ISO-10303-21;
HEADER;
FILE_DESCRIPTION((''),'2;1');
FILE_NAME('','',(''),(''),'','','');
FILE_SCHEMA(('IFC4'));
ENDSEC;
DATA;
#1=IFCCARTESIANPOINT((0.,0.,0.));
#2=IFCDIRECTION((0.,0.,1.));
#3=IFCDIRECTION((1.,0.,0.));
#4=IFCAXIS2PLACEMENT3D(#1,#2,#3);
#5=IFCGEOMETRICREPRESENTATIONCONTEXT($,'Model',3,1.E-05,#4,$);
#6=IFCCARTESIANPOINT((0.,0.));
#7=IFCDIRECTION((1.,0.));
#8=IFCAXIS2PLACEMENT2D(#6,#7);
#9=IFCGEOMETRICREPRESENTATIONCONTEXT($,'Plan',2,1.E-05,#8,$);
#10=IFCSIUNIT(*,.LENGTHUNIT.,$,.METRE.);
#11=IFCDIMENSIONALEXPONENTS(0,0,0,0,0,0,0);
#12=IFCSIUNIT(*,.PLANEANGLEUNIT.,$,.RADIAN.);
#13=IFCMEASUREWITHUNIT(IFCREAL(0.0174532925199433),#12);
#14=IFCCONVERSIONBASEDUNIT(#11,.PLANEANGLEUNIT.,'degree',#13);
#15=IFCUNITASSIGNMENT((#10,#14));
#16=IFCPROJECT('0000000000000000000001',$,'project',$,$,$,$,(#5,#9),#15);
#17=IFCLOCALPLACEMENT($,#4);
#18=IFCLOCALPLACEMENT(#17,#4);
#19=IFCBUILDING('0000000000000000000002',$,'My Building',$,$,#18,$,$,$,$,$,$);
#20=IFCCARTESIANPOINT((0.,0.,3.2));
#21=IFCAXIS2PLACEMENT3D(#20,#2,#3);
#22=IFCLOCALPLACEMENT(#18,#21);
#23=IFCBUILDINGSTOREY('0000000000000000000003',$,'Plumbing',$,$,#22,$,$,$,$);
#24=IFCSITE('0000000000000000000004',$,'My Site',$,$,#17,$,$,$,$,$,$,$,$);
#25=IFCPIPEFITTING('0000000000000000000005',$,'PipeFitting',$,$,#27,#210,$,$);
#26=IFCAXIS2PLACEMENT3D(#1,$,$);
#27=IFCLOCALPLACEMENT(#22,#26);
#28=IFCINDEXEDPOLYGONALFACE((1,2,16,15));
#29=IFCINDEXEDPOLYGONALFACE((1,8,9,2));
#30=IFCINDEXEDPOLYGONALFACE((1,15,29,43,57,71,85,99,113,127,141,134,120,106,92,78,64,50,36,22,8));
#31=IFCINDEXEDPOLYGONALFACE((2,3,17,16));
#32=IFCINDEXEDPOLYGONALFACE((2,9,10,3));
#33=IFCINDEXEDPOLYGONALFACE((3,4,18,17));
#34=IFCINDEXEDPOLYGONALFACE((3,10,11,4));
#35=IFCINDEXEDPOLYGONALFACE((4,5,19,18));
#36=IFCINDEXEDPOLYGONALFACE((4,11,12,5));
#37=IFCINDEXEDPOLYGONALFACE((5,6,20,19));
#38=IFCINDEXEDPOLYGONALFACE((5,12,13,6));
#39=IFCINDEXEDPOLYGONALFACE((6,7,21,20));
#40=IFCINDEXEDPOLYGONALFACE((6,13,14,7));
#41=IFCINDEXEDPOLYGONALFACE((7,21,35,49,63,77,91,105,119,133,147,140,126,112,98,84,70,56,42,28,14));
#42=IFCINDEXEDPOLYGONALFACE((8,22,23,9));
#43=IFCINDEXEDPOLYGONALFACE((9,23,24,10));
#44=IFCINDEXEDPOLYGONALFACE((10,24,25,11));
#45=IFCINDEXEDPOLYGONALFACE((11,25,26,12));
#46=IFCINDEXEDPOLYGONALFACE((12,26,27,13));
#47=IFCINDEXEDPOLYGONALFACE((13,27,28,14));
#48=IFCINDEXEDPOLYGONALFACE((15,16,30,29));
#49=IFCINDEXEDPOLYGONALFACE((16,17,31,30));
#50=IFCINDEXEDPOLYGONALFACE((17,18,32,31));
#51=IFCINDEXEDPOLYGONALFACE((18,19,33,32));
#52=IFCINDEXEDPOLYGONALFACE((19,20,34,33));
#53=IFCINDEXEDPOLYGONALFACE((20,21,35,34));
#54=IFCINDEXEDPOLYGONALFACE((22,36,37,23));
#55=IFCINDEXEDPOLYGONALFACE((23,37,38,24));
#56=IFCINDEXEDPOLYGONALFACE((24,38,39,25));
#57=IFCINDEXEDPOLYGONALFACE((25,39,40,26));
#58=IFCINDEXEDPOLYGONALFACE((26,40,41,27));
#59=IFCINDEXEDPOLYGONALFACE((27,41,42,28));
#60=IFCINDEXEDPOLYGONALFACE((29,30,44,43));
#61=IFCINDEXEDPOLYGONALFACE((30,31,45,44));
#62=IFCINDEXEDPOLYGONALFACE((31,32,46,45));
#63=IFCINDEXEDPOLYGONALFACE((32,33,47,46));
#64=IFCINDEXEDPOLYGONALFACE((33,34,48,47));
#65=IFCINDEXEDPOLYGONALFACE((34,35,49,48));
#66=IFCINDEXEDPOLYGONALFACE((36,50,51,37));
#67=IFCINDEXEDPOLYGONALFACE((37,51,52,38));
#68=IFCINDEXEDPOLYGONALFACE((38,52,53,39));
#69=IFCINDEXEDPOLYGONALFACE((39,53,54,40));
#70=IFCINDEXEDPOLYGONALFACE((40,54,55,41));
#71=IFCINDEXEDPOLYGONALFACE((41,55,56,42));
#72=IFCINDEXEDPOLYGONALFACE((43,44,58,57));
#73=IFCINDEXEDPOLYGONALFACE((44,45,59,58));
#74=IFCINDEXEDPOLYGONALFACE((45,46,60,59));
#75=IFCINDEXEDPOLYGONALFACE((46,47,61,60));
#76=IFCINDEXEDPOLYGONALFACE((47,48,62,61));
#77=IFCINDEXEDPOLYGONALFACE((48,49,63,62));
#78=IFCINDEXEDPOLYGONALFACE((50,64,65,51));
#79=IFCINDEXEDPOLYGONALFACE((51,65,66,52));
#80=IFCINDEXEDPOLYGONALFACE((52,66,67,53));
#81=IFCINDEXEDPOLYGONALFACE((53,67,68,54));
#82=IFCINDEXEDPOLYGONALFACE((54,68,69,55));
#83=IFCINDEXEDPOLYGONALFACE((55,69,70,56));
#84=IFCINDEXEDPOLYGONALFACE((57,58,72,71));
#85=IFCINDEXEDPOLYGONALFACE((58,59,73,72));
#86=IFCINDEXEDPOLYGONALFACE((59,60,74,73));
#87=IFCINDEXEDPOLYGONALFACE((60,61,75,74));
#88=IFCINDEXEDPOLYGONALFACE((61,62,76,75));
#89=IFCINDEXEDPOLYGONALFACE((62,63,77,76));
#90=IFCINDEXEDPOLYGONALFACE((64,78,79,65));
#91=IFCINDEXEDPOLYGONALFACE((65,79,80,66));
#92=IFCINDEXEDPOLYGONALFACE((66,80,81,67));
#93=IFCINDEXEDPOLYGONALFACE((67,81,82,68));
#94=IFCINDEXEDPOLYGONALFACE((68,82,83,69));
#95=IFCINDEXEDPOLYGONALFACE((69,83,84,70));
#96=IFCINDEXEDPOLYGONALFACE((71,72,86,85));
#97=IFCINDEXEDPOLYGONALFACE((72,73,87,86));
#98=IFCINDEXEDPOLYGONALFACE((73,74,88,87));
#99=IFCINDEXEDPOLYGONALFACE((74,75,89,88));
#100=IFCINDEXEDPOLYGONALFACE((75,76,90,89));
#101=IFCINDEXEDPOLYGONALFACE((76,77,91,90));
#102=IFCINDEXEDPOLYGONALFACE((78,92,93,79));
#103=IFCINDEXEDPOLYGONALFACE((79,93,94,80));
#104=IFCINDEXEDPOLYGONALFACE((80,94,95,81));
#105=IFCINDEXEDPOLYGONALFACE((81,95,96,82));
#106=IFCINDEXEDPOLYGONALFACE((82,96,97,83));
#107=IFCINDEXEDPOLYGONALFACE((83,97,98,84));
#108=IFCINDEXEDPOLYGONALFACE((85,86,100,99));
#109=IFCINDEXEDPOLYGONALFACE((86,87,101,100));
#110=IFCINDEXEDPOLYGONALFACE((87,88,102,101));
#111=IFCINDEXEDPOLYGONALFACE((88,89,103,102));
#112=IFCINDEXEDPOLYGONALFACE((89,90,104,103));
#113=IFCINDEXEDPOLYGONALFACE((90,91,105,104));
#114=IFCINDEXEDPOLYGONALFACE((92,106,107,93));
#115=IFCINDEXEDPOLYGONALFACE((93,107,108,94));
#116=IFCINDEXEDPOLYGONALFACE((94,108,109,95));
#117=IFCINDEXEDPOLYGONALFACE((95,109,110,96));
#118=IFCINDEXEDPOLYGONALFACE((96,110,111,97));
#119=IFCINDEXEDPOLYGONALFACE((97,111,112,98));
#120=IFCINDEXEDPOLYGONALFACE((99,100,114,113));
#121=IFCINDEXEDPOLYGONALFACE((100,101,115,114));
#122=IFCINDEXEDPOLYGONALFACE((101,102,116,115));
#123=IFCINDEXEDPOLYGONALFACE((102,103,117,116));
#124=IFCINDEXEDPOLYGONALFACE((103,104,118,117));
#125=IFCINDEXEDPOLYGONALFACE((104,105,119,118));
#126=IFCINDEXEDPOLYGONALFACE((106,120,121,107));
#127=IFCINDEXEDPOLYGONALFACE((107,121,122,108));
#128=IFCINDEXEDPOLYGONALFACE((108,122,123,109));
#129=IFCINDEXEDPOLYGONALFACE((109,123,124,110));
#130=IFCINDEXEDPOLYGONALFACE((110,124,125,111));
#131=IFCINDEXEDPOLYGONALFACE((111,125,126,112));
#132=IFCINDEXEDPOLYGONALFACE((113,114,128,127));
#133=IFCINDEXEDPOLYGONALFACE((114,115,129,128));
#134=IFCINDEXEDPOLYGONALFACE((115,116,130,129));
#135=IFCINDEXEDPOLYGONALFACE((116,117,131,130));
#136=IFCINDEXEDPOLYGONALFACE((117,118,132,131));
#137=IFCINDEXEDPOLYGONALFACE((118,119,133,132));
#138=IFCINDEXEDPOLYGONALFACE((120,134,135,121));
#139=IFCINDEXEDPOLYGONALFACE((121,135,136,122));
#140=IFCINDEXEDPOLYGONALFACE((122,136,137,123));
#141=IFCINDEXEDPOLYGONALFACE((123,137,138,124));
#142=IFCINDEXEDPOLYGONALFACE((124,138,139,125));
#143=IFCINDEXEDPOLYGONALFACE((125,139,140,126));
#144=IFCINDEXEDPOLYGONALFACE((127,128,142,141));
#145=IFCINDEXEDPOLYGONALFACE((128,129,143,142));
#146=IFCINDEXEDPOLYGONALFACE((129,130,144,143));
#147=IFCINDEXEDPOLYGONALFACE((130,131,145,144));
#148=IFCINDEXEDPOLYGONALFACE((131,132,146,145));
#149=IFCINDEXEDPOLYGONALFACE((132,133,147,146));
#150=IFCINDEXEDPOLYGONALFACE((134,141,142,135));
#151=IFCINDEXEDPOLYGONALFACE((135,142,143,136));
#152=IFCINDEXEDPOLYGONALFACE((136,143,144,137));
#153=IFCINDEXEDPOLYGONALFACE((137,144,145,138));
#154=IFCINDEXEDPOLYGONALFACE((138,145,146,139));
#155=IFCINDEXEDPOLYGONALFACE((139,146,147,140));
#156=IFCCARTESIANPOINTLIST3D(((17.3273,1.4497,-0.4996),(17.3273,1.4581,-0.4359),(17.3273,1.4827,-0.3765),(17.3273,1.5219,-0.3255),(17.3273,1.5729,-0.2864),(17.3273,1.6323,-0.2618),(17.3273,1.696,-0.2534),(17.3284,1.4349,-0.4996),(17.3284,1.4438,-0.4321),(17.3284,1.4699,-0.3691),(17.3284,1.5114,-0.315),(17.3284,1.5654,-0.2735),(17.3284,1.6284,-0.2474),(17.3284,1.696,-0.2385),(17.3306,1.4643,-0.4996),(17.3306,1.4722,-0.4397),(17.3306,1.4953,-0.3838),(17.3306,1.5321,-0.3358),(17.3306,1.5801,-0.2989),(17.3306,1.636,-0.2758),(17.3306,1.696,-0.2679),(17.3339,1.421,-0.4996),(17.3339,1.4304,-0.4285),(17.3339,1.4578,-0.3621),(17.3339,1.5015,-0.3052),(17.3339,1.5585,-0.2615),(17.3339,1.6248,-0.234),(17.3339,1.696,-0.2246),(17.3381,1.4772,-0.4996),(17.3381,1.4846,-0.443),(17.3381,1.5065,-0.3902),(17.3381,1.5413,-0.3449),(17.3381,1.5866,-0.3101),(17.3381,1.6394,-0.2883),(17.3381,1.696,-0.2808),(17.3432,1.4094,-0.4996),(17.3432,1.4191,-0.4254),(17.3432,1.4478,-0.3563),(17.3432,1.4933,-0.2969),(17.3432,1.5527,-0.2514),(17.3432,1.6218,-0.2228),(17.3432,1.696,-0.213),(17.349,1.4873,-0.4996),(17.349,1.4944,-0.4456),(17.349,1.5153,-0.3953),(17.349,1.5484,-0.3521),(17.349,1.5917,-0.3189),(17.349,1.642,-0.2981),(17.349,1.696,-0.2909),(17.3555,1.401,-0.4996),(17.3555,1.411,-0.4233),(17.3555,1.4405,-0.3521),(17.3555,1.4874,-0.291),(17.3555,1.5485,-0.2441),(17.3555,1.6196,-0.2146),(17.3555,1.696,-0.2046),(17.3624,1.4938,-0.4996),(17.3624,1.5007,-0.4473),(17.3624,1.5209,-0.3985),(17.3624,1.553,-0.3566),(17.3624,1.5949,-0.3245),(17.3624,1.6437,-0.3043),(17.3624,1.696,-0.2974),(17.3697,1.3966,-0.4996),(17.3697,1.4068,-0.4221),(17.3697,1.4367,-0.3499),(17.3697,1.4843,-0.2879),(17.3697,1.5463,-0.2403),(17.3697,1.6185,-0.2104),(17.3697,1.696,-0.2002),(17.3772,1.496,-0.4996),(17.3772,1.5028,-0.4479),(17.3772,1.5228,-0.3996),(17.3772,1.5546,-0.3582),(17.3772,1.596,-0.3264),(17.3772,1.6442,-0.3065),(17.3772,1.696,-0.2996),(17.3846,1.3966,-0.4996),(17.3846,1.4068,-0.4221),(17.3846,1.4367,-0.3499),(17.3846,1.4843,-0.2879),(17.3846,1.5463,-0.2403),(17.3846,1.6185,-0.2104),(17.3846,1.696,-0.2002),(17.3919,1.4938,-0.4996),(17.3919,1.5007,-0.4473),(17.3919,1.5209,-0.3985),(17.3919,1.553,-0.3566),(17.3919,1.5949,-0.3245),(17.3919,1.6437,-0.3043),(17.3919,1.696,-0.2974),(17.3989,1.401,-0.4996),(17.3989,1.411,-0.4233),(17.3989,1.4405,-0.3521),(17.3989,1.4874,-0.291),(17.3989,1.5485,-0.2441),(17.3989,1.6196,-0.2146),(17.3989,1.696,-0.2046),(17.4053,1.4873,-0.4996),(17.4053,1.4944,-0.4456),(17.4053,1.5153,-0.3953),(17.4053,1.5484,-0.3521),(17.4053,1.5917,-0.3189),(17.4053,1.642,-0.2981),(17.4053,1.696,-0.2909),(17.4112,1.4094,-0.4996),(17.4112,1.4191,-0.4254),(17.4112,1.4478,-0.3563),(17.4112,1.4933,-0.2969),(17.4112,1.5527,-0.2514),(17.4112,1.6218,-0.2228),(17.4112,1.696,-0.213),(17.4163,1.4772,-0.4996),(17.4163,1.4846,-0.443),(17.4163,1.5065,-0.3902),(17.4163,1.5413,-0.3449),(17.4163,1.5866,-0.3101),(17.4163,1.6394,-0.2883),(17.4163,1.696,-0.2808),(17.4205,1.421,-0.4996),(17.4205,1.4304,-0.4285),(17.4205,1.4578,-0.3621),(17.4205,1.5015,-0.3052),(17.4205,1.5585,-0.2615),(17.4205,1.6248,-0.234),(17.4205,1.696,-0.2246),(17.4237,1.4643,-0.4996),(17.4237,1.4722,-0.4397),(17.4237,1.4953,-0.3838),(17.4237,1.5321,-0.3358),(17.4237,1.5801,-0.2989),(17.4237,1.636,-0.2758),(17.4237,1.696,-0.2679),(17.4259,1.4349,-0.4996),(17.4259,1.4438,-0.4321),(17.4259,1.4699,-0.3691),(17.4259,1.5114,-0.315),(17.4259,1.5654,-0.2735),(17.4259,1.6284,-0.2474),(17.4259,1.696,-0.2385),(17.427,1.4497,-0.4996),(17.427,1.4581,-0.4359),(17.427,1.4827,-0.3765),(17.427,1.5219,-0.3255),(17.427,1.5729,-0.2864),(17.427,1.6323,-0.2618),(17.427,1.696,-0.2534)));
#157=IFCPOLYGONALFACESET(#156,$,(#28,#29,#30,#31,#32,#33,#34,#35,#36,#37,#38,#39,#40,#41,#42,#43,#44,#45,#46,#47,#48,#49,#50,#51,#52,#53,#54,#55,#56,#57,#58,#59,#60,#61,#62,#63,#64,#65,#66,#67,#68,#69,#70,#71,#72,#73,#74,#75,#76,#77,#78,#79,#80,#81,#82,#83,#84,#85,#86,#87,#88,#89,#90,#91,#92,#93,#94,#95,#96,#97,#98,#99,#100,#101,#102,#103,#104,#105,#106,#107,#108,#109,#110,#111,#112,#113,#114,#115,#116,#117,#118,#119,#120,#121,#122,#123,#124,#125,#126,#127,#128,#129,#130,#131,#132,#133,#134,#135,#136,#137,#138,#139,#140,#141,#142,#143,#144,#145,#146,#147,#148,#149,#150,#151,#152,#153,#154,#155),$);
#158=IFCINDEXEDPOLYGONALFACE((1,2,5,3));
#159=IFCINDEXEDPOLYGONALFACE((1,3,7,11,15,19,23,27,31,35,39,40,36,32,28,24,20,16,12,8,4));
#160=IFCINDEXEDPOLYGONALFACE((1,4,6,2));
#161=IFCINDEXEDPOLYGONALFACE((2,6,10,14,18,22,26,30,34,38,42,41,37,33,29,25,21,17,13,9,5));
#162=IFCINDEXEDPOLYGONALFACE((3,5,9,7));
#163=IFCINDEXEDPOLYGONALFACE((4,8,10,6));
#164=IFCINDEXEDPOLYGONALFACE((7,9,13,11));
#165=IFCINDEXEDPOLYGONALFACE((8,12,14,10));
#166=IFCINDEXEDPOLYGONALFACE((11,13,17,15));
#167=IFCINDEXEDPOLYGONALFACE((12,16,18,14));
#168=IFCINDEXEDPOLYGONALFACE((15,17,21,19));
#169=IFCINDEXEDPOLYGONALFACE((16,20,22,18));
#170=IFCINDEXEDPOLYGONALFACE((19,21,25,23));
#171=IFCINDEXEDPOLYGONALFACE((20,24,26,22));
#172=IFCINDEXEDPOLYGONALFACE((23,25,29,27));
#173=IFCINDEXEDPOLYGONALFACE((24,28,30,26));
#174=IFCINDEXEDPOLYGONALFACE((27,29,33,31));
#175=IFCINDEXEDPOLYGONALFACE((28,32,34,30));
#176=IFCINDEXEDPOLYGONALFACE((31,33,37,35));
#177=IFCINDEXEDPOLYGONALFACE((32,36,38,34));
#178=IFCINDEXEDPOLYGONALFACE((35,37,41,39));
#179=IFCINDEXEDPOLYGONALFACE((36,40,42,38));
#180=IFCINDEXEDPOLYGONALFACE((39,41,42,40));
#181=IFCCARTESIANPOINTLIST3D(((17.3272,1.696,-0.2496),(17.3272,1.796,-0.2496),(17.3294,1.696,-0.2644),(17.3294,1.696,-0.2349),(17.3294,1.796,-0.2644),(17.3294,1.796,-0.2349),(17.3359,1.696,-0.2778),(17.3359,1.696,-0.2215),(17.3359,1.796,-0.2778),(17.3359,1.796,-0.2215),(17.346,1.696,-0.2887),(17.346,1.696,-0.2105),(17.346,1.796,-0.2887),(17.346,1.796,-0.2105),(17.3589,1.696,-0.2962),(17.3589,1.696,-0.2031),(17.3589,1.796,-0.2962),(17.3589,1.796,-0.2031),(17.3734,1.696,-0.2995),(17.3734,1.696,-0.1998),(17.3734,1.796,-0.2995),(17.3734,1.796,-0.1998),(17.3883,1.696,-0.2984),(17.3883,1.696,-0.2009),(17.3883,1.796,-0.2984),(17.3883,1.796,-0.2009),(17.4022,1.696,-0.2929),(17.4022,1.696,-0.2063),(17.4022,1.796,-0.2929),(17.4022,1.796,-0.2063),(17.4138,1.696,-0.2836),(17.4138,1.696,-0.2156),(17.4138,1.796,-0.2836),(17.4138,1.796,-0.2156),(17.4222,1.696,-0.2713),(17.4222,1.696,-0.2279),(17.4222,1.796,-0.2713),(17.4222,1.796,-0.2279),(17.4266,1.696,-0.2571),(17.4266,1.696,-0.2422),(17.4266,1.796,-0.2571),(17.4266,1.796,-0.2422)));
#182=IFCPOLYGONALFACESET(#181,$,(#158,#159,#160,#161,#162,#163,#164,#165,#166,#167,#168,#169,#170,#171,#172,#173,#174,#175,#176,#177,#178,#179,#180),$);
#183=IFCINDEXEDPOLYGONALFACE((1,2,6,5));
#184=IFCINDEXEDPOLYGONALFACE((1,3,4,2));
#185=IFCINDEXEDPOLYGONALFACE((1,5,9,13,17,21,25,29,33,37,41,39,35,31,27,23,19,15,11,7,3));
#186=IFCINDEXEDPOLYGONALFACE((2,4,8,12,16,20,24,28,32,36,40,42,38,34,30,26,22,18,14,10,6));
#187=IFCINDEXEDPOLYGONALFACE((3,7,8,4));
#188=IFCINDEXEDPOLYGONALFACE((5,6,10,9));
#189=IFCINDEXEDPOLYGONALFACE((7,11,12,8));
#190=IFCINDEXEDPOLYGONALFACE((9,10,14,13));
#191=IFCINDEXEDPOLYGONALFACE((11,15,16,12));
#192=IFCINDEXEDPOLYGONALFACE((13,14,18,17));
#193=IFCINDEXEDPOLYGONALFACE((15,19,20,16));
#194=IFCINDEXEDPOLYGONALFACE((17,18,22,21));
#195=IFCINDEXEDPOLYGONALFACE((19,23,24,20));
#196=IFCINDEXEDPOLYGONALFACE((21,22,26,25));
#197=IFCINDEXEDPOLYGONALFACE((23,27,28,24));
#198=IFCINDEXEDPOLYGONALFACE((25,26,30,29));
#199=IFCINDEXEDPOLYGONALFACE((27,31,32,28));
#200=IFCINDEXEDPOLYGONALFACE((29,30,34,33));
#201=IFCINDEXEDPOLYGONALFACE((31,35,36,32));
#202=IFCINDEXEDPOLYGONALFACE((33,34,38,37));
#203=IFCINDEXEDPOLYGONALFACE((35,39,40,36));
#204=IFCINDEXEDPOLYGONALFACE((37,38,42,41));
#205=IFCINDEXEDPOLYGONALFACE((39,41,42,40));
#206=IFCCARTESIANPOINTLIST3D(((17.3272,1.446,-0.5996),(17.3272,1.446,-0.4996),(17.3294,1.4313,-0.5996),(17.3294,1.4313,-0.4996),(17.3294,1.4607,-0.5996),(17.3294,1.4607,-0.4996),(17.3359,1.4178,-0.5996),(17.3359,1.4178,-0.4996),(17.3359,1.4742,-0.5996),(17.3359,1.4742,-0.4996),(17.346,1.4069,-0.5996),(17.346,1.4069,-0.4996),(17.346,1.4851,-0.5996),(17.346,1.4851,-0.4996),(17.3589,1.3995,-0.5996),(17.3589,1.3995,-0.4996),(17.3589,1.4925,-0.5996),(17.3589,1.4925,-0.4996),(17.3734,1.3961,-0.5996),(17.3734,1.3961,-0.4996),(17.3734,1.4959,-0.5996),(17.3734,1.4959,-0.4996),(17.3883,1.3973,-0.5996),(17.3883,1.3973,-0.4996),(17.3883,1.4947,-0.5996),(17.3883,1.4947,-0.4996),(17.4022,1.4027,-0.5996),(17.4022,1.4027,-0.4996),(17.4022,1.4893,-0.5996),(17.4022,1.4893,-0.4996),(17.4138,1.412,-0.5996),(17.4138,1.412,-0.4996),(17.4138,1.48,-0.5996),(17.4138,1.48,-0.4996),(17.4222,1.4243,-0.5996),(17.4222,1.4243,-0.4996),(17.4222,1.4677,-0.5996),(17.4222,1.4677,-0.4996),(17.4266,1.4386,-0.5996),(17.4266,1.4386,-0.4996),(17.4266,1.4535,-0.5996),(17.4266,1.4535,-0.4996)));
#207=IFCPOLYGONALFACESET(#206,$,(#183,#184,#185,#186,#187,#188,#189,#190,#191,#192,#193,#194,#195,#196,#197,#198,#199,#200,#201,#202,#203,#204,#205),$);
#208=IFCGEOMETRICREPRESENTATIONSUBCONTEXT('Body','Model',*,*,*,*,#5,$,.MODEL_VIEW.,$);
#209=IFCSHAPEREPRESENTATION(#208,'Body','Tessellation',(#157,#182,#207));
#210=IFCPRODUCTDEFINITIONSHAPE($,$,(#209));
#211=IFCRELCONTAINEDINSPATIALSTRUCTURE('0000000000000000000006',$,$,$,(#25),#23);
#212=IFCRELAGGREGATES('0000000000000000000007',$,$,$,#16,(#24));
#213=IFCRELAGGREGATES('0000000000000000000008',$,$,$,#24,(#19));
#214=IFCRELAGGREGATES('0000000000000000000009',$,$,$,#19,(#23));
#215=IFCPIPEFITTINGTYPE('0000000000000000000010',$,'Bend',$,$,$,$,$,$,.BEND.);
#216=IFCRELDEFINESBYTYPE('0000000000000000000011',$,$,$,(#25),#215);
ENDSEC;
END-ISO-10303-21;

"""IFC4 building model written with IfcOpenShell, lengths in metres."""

from ifc_helpers import new_model, entity, si_unit, converted_unit, frame, origin_with_axes, origin_2d_with_axis, place, context, subcontext, project, spatial, circle, extrude, source, transform, mapped, type_object, type_shapes, element, save


model = new_model("IFC4")

# Units and contexts
model_context = context("Model", 3, precision=1e-05, world=origin_with_axes())
plan_context = context("Plan", 2, precision=1e-05, world=origin_2d_with_axis())
body_context = subcontext(model_context, "Body", "Model", "MODEL_VIEW")
ifc_project = project(units=[si_unit("LENGTHUNIT", "METRE"), converted_unit("PLANEANGLEUNIT", "degree", entity("IfcReal", 0.0174532925199433), si_unit("PLANEANGLEUNIT", "RADIAN"), dimensions=[0, 0, 0, 0, 0, 0, 0])], contexts=[model_context, plan_context])

# Site, building, storey
site_placement = place(None, origin_with_axes())
site = spatial("IfcSite", under=ifc_project, at=site_placement, Name="My Site")
building_placement = place(site_placement, origin_with_axes())
building = spatial("IfcBuilding", under=site, at=building_placement, Name="My Building")
storey_placement = place(building_placement, frame((0.0, 0.0, 3.2), z_axis=(0.0, 0.0, 1.0), x_axis=(1.0, 0.0, 0.0)))
storey = spatial("IfcBuildingStorey", under=building, at=storey_placement, Name="Plumbing")

# Pipe fitting
pipe_fitting_type = type_object("IfcPipeFittingType", Name="Bend", PredefinedType="BEND")
shared_shape = source(origin_with_axes(), body_context, "Body", "SolidModel", [
    entity("IfcSweptDiskSolid", entity("IfcIndexedPolyCurve", entity("IfcCartesianPointList3D", [[0.0, 0.0, -0.1], [0.0, -0.0732, -0.2768], [0.0, -0.25, -0.35]]), [entity("IfcArcIndex", [1, 2, 3])]), 0.05),
    extrude(circle(Radius=0.05), origin_with_axes(), (0.0, 0.0, -1.0), 0.1),
    extrude(circle(Radius=0.05), frame((0.0, -0.25, -0.35), z_axis=(0.0, -1.0, 0.0), x_axis=(1.0, 0.0, 0.0)), (0.0, 0.0, 1.0), 0.1),
])
type_shapes(pipe_fitting_type, [shared_shape])
for number, where, z_axis, x_axis, name in (
    (1, (17.3772, 1.796, -0.2496), (0.0, 1.0, 0.0), (-1.0, 0.0, 0.0), "PipeFitting"),
):
    element("IfcPipeFitting", number, at=place(storey_placement, frame(where, z_axis=z_axis, x_axis=x_axis)), inside=storey, type_object=pipe_fitting_type, Name=name, context=body_context, shape_type="MappedRepresentation", body=[
        mapped(shared_shape, transform((0.0, 0.0, 0.0), x_axis=(1.0, 0.0, 0.0), y_axis=(0.0, 1.0, 0.0), z_axis=(0.0, 0.0, 1.0), scale=1.0)),
    ])

save(model, "model.ifc")
